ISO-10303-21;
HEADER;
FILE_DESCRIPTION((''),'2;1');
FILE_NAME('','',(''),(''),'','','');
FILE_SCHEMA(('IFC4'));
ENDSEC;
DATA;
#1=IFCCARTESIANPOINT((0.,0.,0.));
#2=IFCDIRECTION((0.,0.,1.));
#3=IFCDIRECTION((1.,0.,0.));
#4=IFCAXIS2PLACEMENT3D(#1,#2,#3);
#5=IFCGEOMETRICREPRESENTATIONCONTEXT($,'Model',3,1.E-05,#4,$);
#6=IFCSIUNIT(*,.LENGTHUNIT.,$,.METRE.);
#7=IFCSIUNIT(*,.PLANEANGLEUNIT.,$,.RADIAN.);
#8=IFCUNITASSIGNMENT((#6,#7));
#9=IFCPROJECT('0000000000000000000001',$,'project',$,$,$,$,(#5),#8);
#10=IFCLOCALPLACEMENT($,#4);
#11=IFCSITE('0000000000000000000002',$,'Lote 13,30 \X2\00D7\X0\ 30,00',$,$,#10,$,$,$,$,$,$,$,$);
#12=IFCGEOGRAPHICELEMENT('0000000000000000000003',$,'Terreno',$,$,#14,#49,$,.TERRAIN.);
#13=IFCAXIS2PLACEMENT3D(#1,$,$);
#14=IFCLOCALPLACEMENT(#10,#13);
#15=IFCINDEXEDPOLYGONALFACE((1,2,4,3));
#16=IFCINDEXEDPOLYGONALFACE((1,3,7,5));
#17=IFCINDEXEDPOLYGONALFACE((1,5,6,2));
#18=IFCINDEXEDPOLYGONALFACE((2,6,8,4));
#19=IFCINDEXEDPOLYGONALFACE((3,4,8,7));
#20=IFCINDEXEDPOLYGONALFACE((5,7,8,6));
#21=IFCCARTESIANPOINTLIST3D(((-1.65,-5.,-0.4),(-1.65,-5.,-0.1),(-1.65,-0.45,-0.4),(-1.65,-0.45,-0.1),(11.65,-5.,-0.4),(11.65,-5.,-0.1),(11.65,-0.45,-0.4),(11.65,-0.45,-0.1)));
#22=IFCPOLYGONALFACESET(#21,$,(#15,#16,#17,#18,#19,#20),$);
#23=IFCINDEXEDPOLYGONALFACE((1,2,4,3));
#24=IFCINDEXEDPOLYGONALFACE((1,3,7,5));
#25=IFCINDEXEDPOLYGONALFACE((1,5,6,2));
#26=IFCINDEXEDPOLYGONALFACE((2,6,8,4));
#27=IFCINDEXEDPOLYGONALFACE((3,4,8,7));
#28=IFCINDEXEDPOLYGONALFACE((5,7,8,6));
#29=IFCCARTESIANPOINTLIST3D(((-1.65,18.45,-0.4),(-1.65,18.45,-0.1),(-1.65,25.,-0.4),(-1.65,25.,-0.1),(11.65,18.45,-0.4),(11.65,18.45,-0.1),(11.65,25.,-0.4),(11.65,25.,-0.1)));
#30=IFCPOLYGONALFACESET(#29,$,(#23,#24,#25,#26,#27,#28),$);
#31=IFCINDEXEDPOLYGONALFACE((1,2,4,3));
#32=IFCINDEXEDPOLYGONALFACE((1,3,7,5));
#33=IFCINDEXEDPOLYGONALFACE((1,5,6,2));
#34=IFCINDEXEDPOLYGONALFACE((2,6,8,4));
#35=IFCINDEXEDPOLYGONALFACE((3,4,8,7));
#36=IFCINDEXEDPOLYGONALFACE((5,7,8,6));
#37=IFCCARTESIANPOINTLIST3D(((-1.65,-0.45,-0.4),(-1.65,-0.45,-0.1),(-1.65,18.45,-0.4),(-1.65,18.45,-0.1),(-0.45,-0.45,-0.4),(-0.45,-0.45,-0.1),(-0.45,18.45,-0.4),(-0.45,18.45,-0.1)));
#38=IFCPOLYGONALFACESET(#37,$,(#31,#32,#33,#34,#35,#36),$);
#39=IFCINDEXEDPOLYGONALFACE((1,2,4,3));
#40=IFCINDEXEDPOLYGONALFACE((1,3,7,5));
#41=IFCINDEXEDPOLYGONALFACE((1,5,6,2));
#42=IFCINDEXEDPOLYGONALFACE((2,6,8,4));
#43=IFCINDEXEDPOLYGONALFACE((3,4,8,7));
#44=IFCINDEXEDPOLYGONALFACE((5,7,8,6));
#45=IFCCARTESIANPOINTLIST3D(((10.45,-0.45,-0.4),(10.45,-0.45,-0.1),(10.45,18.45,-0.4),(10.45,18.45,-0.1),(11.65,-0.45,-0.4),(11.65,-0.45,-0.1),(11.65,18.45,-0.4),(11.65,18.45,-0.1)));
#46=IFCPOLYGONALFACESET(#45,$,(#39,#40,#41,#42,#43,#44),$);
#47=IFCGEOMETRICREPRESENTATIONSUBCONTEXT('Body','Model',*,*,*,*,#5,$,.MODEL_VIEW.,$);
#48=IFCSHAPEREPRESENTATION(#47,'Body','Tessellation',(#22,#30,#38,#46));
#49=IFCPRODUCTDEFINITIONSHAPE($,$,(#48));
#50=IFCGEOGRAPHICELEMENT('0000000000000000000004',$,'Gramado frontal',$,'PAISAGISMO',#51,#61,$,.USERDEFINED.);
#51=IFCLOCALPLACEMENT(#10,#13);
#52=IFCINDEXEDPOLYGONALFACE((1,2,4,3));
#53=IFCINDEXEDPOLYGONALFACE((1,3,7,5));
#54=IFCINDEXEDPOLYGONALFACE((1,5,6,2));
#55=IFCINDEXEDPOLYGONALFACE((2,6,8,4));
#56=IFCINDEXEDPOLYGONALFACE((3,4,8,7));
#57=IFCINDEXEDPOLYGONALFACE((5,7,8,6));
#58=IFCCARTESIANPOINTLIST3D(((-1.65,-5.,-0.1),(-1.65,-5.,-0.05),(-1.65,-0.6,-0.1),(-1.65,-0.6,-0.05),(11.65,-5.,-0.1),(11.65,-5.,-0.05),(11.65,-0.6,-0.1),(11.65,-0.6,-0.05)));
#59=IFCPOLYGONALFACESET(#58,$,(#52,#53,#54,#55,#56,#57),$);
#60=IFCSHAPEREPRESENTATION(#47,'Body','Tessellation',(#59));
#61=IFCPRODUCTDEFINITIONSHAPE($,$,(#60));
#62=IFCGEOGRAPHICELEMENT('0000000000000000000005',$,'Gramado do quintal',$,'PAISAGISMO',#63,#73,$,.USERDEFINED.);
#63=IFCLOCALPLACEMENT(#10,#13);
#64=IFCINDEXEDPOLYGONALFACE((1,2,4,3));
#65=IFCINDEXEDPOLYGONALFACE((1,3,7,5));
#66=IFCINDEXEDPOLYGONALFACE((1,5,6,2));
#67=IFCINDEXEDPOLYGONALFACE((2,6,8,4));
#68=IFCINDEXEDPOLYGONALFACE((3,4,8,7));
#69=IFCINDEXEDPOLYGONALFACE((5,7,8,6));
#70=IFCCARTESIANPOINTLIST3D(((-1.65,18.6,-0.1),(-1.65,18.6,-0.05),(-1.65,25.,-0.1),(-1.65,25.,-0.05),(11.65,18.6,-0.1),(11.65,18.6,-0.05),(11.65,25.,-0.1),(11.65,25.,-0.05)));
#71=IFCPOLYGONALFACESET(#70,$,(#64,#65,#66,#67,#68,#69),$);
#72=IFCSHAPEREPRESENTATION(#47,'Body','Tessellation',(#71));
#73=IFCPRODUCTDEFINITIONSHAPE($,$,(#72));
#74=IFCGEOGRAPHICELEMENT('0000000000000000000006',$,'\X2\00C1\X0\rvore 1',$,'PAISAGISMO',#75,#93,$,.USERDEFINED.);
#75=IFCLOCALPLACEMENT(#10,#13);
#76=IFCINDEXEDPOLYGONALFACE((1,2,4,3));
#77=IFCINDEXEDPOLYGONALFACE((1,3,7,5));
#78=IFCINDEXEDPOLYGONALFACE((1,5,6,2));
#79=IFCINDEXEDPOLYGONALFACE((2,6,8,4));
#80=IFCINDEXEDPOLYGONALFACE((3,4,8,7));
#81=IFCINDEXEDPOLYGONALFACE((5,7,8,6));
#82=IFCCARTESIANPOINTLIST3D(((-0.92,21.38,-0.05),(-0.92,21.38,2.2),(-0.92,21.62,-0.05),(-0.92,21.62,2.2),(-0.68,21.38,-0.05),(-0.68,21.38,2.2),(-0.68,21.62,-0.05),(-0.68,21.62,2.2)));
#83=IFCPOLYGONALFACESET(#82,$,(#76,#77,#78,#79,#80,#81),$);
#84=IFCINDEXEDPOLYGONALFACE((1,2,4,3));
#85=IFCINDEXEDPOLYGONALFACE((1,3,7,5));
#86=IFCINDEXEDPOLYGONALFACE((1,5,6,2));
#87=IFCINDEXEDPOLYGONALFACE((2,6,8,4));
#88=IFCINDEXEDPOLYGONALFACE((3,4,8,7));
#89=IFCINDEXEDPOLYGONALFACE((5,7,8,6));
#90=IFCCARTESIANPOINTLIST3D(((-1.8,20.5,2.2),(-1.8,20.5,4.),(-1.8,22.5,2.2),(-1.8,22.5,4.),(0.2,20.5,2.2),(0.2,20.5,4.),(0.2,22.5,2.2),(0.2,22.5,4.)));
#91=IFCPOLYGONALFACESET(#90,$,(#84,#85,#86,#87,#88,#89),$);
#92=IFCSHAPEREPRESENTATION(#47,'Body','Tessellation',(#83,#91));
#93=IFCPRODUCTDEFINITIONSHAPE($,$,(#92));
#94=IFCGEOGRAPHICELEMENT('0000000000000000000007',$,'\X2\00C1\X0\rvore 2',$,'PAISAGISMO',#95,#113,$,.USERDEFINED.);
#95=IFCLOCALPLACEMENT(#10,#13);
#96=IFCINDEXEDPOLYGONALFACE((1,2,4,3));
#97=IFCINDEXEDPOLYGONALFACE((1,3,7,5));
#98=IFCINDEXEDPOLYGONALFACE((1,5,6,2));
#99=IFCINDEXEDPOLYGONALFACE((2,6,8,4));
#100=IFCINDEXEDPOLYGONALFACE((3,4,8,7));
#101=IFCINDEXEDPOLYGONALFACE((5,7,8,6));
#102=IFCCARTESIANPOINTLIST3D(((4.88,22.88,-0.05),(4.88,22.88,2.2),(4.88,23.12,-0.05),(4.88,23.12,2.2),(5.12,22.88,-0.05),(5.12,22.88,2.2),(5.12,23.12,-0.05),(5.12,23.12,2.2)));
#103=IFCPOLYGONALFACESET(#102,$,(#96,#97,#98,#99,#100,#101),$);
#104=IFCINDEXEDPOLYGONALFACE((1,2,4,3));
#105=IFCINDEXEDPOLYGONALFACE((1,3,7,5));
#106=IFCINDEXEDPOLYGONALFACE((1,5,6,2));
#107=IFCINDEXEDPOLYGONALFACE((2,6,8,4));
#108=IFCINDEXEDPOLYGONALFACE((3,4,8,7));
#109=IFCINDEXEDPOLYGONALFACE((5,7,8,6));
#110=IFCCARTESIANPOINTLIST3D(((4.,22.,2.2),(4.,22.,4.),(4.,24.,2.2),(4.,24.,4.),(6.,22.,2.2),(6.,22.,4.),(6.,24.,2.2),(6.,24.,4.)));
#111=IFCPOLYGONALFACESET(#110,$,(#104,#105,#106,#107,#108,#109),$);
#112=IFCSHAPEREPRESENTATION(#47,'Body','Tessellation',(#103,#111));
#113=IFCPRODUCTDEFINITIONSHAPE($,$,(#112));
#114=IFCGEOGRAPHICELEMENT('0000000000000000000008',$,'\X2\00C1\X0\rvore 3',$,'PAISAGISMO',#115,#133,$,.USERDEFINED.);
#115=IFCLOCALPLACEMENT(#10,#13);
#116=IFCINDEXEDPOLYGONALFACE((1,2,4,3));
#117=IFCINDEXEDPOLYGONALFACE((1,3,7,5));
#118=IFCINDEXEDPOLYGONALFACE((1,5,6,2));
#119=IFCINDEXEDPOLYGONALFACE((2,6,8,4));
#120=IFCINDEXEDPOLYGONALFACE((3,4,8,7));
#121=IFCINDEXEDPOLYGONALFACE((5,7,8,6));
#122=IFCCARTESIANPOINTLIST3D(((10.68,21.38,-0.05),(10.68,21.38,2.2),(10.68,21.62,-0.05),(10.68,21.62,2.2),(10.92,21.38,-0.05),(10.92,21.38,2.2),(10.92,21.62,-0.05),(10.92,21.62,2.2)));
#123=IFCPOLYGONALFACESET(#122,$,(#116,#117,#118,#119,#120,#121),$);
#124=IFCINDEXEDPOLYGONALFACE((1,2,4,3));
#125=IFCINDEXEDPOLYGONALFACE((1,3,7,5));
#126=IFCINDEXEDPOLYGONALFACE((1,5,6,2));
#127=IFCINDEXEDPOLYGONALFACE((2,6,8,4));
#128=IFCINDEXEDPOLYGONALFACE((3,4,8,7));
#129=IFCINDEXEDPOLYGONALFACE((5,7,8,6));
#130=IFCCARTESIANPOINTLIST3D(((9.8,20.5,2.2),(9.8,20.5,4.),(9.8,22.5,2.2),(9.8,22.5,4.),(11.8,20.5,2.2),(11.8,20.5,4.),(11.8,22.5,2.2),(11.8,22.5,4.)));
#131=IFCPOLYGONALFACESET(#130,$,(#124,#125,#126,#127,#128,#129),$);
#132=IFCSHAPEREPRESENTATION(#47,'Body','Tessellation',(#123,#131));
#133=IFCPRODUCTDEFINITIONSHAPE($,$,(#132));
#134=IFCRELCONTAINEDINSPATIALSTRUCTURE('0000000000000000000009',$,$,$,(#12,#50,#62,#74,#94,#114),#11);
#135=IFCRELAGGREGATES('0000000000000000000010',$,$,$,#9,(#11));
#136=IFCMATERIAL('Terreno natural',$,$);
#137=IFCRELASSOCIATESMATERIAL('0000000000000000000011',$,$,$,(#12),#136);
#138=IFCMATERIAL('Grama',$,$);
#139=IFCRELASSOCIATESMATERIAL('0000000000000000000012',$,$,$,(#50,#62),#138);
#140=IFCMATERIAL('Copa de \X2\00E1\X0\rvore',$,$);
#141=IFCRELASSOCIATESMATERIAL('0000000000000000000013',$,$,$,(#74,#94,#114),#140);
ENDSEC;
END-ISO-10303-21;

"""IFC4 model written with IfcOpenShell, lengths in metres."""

from ifc_helpers import new_model, si_unit, frame, origin_with_axes, place, context, subcontext, project, spatial, line, indexed_curve, outline, extrude, material, element, save


model = new_model("IFC4")

# Units and contexts
model_context = context("Model", 3, precision=1e-05, world=origin_with_axes())
body_context = subcontext(model_context, "Body", "Model", "MODEL_VIEW")
ifc_project = project(units=[si_unit("LENGTHUNIT", "METRE"), si_unit("PLANEANGLEUNIT", "RADIAN")], contexts=[model_context])

# Site
site_placement = place(None, origin_with_axes())
site = spatial("IfcSite", under=ifc_project, at=site_placement, Name="Lote 13,30 × 30,00")

# Geographic elements
ifc_material_1 = material(Name="Terreno natural")
geographic_element_1_placement = place(site_placement, frame((-1.65, -5.0, -0.4), z_axis=(0.0, 0.0, 1.0), x_axis=(1.0, 0.0, 0.0)))
element("IfcGeographicElement", 1, at=geographic_element_1_placement, inside=site, material=ifc_material_1, Name="Terreno", PredefinedType="TERRAIN", context=body_context, shape_type="SweptSolid", body=[
    extrude(outline(indexed_curve([(0.0, 0.0), (13.3, 0.0), (13.3, 4.55), (0.0, 4.55)], segments=[line(1, 2, 3, 4, 1)])), origin_with_axes(), (0.0, 0.0, 1.0), 0.3),
    extrude(outline(indexed_curve([(0.0, 23.45), (13.3, 23.45), (13.3, 30.0), (0.0, 30.0)], segments=[line(1, 2, 3, 4, 1)])), origin_with_axes(), (0.0, 0.0, 1.0), 0.3),
    extrude(outline(indexed_curve([(0.0, 4.55), (1.2, 4.55), (1.2, 23.45), (0.0, 23.45)], segments=[line(1, 2, 3, 4, 1)])), origin_with_axes(), (0.0, 0.0, 1.0), 0.3),
    extrude(outline(indexed_curve([(12.1, 4.55), (13.3, 4.55), (13.3, 23.45), (12.1, 23.45)], segments=[line(1, 2, 3, 4, 1)])), origin_with_axes(), (0.0, 0.0, 1.0), 0.3),
])
ifc_material_2 = material(Name="Grama")
geographic_element_2_placement = place(site_placement, frame((-1.65, -5.0, -0.1), z_axis=(0.0, 0.0, 1.0), x_axis=(1.0, 0.0, 0.0)))
element("IfcGeographicElement", 2, at=geographic_element_2_placement, inside=site, material=ifc_material_2, Name="Gramado frontal", ObjectType="PAISAGISMO", PredefinedType="USERDEFINED", context=body_context, shape_type="SweptSolid", body=[
    extrude(outline(indexed_curve([(0.0, 0.0), (13.3, 0.0), (13.3, 4.4), (0.0, 4.4)], segments=[line(1, 2, 3, 4, 1)])), origin_with_axes(), (0.0, 0.0, 1.0), 0.05),
])
geographic_element_3_placement = place(site_placement, frame((-1.65, 18.6, -0.1), z_axis=(0.0, 0.0, 1.0), x_axis=(1.0, 0.0, 0.0)))
element("IfcGeographicElement", 3, at=geographic_element_3_placement, inside=site, material=ifc_material_2, Name="Gramado do quintal", ObjectType="PAISAGISMO", PredefinedType="USERDEFINED", context=body_context, shape_type="SweptSolid", body=[
    extrude(outline(indexed_curve([(0.0, 0.0), (13.3, 0.0), (13.3, 6.4), (0.0, 6.4)], segments=[line(1, 2, 3, 4, 1)])), origin_with_axes(), (0.0, 0.0, 1.0), 0.05),
])
ifc_material_3 = material(Name="Copa de árvore")
geographic_element_4_placement = place(site_placement, frame((-1.8, 20.5, -0.05), z_axis=(0.0, 0.0, 1.0), x_axis=(1.0, 0.0, 0.0)))
element("IfcGeographicElement", 4, at=geographic_element_4_placement, inside=site, material=ifc_material_3, Name="Árvore 1", ObjectType="PAISAGISMO", PredefinedType="USERDEFINED", context=body_context, shape_type="SweptSolid", body=[
    extrude(outline(indexed_curve([(0.88, 0.88), (1.12, 0.88), (1.12, 1.12), (0.88, 1.12)], segments=[line(1, 2, 3, 4, 1)])), origin_with_axes(), (0.0, 0.0, 1.0), 2.25),
    extrude(outline(indexed_curve([(0.0, 0.0), (2.0, 0.0), (2.0, 2.0), (0.0, 2.0)], segments=[line(1, 2, 3, 4, 1)])), frame((0.0, 0.0, 2.25), z_axis=(0.0, 0.0, 1.0), x_axis=(1.0, 0.0, 0.0)), (0.0, 0.0, 1.0), 1.8),
])
geographic_element_5_placement = place(site_placement, frame((4.0, 22.0, -0.05), z_axis=(0.0, 0.0, 1.0), x_axis=(1.0, 0.0, 0.0)))
element("IfcGeographicElement", 5, at=geographic_element_5_placement, inside=site, material=ifc_material_3, Name="Árvore 2", ObjectType="PAISAGISMO", PredefinedType="USERDEFINED", context=body_context, shape_type="SweptSolid", body=[
    extrude(outline(indexed_curve([(0.88, 0.88), (1.12, 0.88), (1.12, 1.12), (0.88, 1.12)], segments=[line(1, 2, 3, 4, 1)])), origin_with_axes(), (0.0, 0.0, 1.0), 2.25),
    extrude(outline(indexed_curve([(0.0, 0.0), (2.0, 0.0), (2.0, 2.0), (0.0, 2.0)], segments=[line(1, 2, 3, 4, 1)])), frame((0.0, 0.0, 2.25), z_axis=(0.0, 0.0, 1.0), x_axis=(1.0, 0.0, 0.0)), (0.0, 0.0, 1.0), 1.8),
])
geographic_element_6_placement = place(site_placement, frame((9.8, 20.5, -0.05), z_axis=(0.0, 0.0, 1.0), x_axis=(1.0, 0.0, 0.0)))
element("IfcGeographicElement", 6, at=geographic_element_6_placement, inside=site, material=ifc_material_3, Name="Árvore 3", ObjectType="PAISAGISMO", PredefinedType="USERDEFINED", context=body_context, shape_type="SweptSolid", body=[
    extrude(outline(indexed_curve([(0.88, 0.88), (1.12, 0.88), (1.12, 1.12), (0.88, 1.12)], segments=[line(1, 2, 3, 4, 1)])), origin_with_axes(), (0.0, 0.0, 1.0), 2.25),
    extrude(outline(indexed_curve([(0.0, 0.0), (2.0, 0.0), (2.0, 2.0), (0.0, 2.0)], segments=[line(1, 2, 3, 4, 1)])), frame((0.0, 0.0, 2.25), z_axis=(0.0, 0.0, 1.0), x_axis=(1.0, 0.0, 0.0)), (0.0, 0.0, 1.0), 1.8),
])

save(model, "model.ifc")
